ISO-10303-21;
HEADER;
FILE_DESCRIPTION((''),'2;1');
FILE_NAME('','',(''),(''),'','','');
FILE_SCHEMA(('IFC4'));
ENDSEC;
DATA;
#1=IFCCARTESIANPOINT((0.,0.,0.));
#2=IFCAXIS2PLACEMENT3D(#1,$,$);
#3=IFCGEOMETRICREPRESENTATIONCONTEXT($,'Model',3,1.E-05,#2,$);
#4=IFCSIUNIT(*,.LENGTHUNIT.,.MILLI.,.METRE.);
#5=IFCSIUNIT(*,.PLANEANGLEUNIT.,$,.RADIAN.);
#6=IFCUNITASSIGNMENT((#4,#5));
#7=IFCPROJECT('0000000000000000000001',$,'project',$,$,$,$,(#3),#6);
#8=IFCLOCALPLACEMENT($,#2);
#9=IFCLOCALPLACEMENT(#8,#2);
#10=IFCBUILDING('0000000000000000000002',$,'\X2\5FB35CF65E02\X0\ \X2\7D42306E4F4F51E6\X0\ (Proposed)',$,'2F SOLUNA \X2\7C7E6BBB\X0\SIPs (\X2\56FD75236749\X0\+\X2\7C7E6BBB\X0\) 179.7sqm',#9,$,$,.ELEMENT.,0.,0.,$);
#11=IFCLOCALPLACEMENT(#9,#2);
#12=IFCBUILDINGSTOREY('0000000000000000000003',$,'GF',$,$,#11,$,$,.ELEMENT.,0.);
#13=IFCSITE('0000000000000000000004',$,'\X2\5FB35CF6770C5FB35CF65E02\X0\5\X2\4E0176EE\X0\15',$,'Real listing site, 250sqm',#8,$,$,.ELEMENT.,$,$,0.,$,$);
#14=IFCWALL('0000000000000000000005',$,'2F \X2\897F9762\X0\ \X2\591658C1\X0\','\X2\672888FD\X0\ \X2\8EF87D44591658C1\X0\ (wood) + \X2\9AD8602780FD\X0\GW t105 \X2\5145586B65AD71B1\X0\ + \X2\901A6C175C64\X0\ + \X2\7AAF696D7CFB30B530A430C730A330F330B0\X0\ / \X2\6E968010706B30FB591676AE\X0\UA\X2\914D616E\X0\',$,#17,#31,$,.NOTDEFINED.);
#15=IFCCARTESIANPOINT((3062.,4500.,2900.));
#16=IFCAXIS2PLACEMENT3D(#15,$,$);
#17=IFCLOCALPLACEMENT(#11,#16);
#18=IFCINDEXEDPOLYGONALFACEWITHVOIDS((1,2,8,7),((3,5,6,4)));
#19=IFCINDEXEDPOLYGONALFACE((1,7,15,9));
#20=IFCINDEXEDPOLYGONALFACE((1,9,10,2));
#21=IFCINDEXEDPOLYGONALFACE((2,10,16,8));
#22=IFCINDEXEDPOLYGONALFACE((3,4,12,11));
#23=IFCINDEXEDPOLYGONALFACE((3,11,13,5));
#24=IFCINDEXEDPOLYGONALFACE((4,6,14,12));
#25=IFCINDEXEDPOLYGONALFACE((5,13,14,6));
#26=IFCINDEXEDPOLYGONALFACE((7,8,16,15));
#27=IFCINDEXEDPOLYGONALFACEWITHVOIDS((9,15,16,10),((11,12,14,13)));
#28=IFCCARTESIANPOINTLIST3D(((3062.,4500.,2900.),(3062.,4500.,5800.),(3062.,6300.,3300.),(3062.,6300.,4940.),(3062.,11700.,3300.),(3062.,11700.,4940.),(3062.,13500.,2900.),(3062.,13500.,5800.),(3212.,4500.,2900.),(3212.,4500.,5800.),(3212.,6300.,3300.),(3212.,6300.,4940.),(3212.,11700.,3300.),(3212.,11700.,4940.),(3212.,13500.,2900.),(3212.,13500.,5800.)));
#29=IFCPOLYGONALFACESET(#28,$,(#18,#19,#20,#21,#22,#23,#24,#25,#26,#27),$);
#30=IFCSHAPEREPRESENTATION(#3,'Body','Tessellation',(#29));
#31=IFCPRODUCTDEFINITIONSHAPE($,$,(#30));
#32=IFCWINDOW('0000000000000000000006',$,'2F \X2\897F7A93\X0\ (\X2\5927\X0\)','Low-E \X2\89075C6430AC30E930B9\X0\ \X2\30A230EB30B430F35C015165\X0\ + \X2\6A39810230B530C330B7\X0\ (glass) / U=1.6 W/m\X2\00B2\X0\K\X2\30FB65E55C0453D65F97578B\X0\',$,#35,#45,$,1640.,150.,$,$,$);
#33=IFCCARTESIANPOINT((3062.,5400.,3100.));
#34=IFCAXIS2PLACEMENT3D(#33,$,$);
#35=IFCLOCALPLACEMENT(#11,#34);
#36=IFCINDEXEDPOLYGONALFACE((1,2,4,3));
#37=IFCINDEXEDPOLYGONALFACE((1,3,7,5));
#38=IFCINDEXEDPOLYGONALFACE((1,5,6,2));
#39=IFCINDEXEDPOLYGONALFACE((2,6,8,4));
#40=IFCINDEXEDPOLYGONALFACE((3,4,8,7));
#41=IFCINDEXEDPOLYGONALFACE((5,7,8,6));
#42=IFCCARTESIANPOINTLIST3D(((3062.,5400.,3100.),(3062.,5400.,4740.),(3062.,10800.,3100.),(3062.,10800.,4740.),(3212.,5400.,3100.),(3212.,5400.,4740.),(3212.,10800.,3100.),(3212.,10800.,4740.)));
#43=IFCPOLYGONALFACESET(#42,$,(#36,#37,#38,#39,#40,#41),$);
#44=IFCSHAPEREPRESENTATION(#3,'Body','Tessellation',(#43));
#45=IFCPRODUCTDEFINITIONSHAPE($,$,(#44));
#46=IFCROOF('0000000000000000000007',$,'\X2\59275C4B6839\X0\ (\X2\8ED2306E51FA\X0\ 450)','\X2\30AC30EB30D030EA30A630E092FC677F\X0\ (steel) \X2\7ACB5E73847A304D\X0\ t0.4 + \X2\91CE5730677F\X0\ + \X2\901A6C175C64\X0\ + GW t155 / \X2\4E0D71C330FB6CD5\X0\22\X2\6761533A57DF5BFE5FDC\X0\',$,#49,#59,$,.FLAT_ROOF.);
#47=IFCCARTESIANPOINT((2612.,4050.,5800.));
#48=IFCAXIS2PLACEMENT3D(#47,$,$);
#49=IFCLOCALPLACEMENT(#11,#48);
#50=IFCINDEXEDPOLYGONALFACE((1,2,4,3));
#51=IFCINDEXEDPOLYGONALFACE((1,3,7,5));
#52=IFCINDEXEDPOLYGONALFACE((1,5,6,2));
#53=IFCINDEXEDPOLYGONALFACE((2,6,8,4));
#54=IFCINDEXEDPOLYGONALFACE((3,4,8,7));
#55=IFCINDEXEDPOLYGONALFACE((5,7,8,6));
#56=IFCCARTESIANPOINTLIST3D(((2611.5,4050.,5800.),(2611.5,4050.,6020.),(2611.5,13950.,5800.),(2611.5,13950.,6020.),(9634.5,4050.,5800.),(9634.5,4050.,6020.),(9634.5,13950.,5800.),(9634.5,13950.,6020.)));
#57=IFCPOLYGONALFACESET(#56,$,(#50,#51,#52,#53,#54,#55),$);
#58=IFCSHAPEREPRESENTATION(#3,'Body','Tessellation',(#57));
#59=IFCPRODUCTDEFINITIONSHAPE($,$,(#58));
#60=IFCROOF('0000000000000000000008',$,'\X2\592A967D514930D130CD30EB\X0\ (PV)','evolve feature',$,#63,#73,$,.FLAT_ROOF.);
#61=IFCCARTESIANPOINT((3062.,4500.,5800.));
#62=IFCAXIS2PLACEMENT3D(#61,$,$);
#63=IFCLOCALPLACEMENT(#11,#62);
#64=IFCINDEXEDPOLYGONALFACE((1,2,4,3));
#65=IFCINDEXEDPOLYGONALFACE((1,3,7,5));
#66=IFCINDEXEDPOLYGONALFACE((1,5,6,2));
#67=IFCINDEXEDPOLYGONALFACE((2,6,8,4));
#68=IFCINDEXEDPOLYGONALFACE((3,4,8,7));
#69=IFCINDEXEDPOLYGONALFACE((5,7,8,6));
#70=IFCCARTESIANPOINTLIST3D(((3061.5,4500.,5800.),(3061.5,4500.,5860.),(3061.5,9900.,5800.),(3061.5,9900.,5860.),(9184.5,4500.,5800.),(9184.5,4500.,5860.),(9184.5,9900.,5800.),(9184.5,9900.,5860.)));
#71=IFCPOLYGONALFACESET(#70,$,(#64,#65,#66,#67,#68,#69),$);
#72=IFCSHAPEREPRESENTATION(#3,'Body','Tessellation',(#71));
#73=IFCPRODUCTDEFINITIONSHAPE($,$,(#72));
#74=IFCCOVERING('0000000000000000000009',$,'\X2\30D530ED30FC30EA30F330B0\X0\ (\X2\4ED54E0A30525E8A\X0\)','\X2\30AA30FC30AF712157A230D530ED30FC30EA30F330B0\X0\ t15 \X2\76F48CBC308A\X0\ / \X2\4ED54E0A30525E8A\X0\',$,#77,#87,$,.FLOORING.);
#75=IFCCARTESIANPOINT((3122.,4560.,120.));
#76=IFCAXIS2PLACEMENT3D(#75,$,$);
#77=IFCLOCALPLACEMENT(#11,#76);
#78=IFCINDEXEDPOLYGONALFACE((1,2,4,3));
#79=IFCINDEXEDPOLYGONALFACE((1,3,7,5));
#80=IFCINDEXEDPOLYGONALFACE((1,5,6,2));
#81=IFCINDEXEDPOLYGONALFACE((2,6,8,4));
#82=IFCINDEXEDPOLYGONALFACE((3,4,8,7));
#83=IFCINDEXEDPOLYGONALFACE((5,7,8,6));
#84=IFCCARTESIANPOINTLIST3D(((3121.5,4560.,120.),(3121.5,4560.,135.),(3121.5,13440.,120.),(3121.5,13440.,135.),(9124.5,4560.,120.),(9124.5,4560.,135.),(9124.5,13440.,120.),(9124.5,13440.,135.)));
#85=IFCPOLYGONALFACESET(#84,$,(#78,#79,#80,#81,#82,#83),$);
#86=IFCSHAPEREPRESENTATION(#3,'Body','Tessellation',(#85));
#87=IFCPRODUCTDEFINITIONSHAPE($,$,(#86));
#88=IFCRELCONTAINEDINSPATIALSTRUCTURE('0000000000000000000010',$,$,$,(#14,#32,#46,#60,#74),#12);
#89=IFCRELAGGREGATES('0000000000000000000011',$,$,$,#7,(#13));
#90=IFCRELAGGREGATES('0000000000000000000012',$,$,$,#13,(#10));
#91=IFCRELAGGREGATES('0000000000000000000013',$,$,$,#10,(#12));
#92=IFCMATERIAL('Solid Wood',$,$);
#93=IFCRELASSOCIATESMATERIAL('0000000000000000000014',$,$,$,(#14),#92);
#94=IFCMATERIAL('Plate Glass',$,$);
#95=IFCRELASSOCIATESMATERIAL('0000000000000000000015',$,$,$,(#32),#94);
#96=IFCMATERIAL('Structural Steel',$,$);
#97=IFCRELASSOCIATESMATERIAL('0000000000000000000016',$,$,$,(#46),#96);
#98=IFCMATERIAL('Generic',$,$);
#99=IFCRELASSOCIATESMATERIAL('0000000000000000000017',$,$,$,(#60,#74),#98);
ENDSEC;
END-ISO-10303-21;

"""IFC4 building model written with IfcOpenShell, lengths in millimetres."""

from ifc_helpers import new_model, si_unit, frame, frame_2d, origin, place, context, project, spatial, rectangle, extrude, material, element, fill, save


model = new_model("IFC4")

# Units and contexts
model_context = context("Model", 3, precision=1e-05, world=origin())
ifc_project = project(units=[si_unit("LENGTHUNIT", "METRE", prefix="MILLI"), si_unit("PLANEANGLEUNIT", "RADIAN")], contexts=[model_context])

# Site, building, storey
site_placement = place(None, origin())
site = spatial("IfcSite", under=ifc_project, at=site_placement, Name="徳島県徳島市5丁目15", ObjectType="Real listing site, 250sqm", CompositionType="ELEMENT", RefElevation=0.0)
building_placement = place(site_placement, origin())
building = spatial("IfcBuilding", under=site, at=building_placement, Name="徳島市 終の住処 (Proposed)", ObjectType="2F SOLUNA 籾殻SIPs (国産杉+籾殻) 179.7sqm", CompositionType="ELEMENT", ElevationOfRefHeight=0.0, ElevationOfTerrain=0.0)
storey_placement = place(building_placement, origin())
storey = spatial("IfcBuildingStorey", under=building, at=storey_placement, Name="GF", CompositionType="ELEMENT", Elevation=0.0)

# Shared definitions
ifc_material_1 = material(Name="Solid Wood")
ifc_material_2 = material(Name="Generic")

# Shared definitions
ifc_material_3 = material(Name="Plate Glass")

# Wall, opening, window
wall_1_placement = place(storey_placement, frame((3062.0, 4500.0, 2900.0)))
wall_1 = element("IfcWall", 1, at=wall_1_placement, inside=storey, material=ifc_material_1, Name="2F 西面 外壁", Description="木製 軸組外壁 (wood) + 高性能GW t105 充填断熱 + 通気層 + 窯業系サイディング / 準耐火・外皮UA配慮", PredefinedType="NOTDEFINED", context=model_context, shape_type="SweptSolid", body=[
    extrude(rectangle(XDim=150.0, YDim=9000.0, at=frame_2d((75.0, 4500.0))), frame((3062.0, 4500.0, 2900.0)), (0.0, 0.0, 1.0), 2900.0),
])
opening_1_placement = place(storey_placement, frame((3062.0, 5400.0, 3100.0)))
opening_1 = element("IfcOpeningElement", 2, at=opening_1_placement, cuts=wall_1, PredefinedType="NOTDEFINED", context=model_context, shape_type="SweptSolid", body=[
    extrude(rectangle(XDim=150.0, YDim=5400.0, at=frame_2d((75.0, 2700.0))), frame((3062.0, 5400.0, 3100.0)), (0.0, 0.0, 1.0), 1640.0),
])
window_1_placement = place(storey_placement, frame((3062.0, 5400.0, 3100.0)))
window_1 = element("IfcWindow", 3, at=window_1_placement, inside=storey, material=ifc_material_3, Name="2F 西窓 (大)", Description="Low-E 複層ガラス アルゴン封入 + 樹脂サッシ (glass) / U=1.6 W/m²K・日射取得型", OverallHeight=1640.0, OverallWidth=150.0, context=model_context, shape_type="SweptSolid", body=[
    extrude(rectangle(XDim=150.0, YDim=5400.0, at=frame_2d((75.0, 2700.0))), frame((3062.0, 5400.0, 3100.0)), (0.0, 0.0, 1.0), 1640.0),
])
fill(opening_1, window_1)

# Roofs
ifc_material_4 = material(Name="Structural Steel")
roof_1_placement = place(storey_placement, frame((2612.0, 4050.0, 5800.0)))
element("IfcRoof", 4, at=roof_1_placement, inside=storey, material=ifc_material_4, Name="大屋根 (軒の出 450)", Description="ガルバリウム鋼板 (steel) 立平葺き t0.4 + 野地板 + 通気層 + GW t155 / 不燃・法22条区域対応", PredefinedType="FLAT_ROOF", context=model_context, shape_type="SweptSolid", body=[
    extrude(rectangle(XDim=7023.0, YDim=9900.0, at=frame_2d((3511.0, 4950.0))), frame((2612.0, 4050.0, 5800.0)), (0.0, 0.0, 1.0), 220.0),
])
roof_2_placement = place(storey_placement, frame((3062.0, 4500.0, 5800.0)))
element("IfcRoof", 5, at=roof_2_placement, inside=storey, material=ifc_material_2, Name="太陽光パネル (PV)", Description="evolve feature", PredefinedType="FLAT_ROOF", context=model_context, shape_type="SweptSolid", body=[
    extrude(rectangle(XDim=6123.0, YDim=5400.0, at=frame_2d((3061.0, 2700.0))), frame((3062.0, 4500.0, 5800.0)), (0.0, 0.0, 1.0), 60.0),
])

# Covering
covering_placement = place(storey_placement, frame((3122.0, 4560.0, 120.0)))
element("IfcCovering", 6, at=covering_placement, inside=storey, material=ifc_material_2, Name="フローリング (仕上げ床)", Description="オーク無垢フローリング t15 直貼り / 仕上げ床", PredefinedType="FLOORING", context=model_context, shape_type="SweptSolid", body=[
    extrude(rectangle(XDim=6003.0, YDim=8880.0, at=frame_2d((3001.0, 4440.0))), frame((3122.0, 4560.0, 120.0)), (0.0, 0.0, 1.0), 15.0),
])

save(model, "model.ifc")
